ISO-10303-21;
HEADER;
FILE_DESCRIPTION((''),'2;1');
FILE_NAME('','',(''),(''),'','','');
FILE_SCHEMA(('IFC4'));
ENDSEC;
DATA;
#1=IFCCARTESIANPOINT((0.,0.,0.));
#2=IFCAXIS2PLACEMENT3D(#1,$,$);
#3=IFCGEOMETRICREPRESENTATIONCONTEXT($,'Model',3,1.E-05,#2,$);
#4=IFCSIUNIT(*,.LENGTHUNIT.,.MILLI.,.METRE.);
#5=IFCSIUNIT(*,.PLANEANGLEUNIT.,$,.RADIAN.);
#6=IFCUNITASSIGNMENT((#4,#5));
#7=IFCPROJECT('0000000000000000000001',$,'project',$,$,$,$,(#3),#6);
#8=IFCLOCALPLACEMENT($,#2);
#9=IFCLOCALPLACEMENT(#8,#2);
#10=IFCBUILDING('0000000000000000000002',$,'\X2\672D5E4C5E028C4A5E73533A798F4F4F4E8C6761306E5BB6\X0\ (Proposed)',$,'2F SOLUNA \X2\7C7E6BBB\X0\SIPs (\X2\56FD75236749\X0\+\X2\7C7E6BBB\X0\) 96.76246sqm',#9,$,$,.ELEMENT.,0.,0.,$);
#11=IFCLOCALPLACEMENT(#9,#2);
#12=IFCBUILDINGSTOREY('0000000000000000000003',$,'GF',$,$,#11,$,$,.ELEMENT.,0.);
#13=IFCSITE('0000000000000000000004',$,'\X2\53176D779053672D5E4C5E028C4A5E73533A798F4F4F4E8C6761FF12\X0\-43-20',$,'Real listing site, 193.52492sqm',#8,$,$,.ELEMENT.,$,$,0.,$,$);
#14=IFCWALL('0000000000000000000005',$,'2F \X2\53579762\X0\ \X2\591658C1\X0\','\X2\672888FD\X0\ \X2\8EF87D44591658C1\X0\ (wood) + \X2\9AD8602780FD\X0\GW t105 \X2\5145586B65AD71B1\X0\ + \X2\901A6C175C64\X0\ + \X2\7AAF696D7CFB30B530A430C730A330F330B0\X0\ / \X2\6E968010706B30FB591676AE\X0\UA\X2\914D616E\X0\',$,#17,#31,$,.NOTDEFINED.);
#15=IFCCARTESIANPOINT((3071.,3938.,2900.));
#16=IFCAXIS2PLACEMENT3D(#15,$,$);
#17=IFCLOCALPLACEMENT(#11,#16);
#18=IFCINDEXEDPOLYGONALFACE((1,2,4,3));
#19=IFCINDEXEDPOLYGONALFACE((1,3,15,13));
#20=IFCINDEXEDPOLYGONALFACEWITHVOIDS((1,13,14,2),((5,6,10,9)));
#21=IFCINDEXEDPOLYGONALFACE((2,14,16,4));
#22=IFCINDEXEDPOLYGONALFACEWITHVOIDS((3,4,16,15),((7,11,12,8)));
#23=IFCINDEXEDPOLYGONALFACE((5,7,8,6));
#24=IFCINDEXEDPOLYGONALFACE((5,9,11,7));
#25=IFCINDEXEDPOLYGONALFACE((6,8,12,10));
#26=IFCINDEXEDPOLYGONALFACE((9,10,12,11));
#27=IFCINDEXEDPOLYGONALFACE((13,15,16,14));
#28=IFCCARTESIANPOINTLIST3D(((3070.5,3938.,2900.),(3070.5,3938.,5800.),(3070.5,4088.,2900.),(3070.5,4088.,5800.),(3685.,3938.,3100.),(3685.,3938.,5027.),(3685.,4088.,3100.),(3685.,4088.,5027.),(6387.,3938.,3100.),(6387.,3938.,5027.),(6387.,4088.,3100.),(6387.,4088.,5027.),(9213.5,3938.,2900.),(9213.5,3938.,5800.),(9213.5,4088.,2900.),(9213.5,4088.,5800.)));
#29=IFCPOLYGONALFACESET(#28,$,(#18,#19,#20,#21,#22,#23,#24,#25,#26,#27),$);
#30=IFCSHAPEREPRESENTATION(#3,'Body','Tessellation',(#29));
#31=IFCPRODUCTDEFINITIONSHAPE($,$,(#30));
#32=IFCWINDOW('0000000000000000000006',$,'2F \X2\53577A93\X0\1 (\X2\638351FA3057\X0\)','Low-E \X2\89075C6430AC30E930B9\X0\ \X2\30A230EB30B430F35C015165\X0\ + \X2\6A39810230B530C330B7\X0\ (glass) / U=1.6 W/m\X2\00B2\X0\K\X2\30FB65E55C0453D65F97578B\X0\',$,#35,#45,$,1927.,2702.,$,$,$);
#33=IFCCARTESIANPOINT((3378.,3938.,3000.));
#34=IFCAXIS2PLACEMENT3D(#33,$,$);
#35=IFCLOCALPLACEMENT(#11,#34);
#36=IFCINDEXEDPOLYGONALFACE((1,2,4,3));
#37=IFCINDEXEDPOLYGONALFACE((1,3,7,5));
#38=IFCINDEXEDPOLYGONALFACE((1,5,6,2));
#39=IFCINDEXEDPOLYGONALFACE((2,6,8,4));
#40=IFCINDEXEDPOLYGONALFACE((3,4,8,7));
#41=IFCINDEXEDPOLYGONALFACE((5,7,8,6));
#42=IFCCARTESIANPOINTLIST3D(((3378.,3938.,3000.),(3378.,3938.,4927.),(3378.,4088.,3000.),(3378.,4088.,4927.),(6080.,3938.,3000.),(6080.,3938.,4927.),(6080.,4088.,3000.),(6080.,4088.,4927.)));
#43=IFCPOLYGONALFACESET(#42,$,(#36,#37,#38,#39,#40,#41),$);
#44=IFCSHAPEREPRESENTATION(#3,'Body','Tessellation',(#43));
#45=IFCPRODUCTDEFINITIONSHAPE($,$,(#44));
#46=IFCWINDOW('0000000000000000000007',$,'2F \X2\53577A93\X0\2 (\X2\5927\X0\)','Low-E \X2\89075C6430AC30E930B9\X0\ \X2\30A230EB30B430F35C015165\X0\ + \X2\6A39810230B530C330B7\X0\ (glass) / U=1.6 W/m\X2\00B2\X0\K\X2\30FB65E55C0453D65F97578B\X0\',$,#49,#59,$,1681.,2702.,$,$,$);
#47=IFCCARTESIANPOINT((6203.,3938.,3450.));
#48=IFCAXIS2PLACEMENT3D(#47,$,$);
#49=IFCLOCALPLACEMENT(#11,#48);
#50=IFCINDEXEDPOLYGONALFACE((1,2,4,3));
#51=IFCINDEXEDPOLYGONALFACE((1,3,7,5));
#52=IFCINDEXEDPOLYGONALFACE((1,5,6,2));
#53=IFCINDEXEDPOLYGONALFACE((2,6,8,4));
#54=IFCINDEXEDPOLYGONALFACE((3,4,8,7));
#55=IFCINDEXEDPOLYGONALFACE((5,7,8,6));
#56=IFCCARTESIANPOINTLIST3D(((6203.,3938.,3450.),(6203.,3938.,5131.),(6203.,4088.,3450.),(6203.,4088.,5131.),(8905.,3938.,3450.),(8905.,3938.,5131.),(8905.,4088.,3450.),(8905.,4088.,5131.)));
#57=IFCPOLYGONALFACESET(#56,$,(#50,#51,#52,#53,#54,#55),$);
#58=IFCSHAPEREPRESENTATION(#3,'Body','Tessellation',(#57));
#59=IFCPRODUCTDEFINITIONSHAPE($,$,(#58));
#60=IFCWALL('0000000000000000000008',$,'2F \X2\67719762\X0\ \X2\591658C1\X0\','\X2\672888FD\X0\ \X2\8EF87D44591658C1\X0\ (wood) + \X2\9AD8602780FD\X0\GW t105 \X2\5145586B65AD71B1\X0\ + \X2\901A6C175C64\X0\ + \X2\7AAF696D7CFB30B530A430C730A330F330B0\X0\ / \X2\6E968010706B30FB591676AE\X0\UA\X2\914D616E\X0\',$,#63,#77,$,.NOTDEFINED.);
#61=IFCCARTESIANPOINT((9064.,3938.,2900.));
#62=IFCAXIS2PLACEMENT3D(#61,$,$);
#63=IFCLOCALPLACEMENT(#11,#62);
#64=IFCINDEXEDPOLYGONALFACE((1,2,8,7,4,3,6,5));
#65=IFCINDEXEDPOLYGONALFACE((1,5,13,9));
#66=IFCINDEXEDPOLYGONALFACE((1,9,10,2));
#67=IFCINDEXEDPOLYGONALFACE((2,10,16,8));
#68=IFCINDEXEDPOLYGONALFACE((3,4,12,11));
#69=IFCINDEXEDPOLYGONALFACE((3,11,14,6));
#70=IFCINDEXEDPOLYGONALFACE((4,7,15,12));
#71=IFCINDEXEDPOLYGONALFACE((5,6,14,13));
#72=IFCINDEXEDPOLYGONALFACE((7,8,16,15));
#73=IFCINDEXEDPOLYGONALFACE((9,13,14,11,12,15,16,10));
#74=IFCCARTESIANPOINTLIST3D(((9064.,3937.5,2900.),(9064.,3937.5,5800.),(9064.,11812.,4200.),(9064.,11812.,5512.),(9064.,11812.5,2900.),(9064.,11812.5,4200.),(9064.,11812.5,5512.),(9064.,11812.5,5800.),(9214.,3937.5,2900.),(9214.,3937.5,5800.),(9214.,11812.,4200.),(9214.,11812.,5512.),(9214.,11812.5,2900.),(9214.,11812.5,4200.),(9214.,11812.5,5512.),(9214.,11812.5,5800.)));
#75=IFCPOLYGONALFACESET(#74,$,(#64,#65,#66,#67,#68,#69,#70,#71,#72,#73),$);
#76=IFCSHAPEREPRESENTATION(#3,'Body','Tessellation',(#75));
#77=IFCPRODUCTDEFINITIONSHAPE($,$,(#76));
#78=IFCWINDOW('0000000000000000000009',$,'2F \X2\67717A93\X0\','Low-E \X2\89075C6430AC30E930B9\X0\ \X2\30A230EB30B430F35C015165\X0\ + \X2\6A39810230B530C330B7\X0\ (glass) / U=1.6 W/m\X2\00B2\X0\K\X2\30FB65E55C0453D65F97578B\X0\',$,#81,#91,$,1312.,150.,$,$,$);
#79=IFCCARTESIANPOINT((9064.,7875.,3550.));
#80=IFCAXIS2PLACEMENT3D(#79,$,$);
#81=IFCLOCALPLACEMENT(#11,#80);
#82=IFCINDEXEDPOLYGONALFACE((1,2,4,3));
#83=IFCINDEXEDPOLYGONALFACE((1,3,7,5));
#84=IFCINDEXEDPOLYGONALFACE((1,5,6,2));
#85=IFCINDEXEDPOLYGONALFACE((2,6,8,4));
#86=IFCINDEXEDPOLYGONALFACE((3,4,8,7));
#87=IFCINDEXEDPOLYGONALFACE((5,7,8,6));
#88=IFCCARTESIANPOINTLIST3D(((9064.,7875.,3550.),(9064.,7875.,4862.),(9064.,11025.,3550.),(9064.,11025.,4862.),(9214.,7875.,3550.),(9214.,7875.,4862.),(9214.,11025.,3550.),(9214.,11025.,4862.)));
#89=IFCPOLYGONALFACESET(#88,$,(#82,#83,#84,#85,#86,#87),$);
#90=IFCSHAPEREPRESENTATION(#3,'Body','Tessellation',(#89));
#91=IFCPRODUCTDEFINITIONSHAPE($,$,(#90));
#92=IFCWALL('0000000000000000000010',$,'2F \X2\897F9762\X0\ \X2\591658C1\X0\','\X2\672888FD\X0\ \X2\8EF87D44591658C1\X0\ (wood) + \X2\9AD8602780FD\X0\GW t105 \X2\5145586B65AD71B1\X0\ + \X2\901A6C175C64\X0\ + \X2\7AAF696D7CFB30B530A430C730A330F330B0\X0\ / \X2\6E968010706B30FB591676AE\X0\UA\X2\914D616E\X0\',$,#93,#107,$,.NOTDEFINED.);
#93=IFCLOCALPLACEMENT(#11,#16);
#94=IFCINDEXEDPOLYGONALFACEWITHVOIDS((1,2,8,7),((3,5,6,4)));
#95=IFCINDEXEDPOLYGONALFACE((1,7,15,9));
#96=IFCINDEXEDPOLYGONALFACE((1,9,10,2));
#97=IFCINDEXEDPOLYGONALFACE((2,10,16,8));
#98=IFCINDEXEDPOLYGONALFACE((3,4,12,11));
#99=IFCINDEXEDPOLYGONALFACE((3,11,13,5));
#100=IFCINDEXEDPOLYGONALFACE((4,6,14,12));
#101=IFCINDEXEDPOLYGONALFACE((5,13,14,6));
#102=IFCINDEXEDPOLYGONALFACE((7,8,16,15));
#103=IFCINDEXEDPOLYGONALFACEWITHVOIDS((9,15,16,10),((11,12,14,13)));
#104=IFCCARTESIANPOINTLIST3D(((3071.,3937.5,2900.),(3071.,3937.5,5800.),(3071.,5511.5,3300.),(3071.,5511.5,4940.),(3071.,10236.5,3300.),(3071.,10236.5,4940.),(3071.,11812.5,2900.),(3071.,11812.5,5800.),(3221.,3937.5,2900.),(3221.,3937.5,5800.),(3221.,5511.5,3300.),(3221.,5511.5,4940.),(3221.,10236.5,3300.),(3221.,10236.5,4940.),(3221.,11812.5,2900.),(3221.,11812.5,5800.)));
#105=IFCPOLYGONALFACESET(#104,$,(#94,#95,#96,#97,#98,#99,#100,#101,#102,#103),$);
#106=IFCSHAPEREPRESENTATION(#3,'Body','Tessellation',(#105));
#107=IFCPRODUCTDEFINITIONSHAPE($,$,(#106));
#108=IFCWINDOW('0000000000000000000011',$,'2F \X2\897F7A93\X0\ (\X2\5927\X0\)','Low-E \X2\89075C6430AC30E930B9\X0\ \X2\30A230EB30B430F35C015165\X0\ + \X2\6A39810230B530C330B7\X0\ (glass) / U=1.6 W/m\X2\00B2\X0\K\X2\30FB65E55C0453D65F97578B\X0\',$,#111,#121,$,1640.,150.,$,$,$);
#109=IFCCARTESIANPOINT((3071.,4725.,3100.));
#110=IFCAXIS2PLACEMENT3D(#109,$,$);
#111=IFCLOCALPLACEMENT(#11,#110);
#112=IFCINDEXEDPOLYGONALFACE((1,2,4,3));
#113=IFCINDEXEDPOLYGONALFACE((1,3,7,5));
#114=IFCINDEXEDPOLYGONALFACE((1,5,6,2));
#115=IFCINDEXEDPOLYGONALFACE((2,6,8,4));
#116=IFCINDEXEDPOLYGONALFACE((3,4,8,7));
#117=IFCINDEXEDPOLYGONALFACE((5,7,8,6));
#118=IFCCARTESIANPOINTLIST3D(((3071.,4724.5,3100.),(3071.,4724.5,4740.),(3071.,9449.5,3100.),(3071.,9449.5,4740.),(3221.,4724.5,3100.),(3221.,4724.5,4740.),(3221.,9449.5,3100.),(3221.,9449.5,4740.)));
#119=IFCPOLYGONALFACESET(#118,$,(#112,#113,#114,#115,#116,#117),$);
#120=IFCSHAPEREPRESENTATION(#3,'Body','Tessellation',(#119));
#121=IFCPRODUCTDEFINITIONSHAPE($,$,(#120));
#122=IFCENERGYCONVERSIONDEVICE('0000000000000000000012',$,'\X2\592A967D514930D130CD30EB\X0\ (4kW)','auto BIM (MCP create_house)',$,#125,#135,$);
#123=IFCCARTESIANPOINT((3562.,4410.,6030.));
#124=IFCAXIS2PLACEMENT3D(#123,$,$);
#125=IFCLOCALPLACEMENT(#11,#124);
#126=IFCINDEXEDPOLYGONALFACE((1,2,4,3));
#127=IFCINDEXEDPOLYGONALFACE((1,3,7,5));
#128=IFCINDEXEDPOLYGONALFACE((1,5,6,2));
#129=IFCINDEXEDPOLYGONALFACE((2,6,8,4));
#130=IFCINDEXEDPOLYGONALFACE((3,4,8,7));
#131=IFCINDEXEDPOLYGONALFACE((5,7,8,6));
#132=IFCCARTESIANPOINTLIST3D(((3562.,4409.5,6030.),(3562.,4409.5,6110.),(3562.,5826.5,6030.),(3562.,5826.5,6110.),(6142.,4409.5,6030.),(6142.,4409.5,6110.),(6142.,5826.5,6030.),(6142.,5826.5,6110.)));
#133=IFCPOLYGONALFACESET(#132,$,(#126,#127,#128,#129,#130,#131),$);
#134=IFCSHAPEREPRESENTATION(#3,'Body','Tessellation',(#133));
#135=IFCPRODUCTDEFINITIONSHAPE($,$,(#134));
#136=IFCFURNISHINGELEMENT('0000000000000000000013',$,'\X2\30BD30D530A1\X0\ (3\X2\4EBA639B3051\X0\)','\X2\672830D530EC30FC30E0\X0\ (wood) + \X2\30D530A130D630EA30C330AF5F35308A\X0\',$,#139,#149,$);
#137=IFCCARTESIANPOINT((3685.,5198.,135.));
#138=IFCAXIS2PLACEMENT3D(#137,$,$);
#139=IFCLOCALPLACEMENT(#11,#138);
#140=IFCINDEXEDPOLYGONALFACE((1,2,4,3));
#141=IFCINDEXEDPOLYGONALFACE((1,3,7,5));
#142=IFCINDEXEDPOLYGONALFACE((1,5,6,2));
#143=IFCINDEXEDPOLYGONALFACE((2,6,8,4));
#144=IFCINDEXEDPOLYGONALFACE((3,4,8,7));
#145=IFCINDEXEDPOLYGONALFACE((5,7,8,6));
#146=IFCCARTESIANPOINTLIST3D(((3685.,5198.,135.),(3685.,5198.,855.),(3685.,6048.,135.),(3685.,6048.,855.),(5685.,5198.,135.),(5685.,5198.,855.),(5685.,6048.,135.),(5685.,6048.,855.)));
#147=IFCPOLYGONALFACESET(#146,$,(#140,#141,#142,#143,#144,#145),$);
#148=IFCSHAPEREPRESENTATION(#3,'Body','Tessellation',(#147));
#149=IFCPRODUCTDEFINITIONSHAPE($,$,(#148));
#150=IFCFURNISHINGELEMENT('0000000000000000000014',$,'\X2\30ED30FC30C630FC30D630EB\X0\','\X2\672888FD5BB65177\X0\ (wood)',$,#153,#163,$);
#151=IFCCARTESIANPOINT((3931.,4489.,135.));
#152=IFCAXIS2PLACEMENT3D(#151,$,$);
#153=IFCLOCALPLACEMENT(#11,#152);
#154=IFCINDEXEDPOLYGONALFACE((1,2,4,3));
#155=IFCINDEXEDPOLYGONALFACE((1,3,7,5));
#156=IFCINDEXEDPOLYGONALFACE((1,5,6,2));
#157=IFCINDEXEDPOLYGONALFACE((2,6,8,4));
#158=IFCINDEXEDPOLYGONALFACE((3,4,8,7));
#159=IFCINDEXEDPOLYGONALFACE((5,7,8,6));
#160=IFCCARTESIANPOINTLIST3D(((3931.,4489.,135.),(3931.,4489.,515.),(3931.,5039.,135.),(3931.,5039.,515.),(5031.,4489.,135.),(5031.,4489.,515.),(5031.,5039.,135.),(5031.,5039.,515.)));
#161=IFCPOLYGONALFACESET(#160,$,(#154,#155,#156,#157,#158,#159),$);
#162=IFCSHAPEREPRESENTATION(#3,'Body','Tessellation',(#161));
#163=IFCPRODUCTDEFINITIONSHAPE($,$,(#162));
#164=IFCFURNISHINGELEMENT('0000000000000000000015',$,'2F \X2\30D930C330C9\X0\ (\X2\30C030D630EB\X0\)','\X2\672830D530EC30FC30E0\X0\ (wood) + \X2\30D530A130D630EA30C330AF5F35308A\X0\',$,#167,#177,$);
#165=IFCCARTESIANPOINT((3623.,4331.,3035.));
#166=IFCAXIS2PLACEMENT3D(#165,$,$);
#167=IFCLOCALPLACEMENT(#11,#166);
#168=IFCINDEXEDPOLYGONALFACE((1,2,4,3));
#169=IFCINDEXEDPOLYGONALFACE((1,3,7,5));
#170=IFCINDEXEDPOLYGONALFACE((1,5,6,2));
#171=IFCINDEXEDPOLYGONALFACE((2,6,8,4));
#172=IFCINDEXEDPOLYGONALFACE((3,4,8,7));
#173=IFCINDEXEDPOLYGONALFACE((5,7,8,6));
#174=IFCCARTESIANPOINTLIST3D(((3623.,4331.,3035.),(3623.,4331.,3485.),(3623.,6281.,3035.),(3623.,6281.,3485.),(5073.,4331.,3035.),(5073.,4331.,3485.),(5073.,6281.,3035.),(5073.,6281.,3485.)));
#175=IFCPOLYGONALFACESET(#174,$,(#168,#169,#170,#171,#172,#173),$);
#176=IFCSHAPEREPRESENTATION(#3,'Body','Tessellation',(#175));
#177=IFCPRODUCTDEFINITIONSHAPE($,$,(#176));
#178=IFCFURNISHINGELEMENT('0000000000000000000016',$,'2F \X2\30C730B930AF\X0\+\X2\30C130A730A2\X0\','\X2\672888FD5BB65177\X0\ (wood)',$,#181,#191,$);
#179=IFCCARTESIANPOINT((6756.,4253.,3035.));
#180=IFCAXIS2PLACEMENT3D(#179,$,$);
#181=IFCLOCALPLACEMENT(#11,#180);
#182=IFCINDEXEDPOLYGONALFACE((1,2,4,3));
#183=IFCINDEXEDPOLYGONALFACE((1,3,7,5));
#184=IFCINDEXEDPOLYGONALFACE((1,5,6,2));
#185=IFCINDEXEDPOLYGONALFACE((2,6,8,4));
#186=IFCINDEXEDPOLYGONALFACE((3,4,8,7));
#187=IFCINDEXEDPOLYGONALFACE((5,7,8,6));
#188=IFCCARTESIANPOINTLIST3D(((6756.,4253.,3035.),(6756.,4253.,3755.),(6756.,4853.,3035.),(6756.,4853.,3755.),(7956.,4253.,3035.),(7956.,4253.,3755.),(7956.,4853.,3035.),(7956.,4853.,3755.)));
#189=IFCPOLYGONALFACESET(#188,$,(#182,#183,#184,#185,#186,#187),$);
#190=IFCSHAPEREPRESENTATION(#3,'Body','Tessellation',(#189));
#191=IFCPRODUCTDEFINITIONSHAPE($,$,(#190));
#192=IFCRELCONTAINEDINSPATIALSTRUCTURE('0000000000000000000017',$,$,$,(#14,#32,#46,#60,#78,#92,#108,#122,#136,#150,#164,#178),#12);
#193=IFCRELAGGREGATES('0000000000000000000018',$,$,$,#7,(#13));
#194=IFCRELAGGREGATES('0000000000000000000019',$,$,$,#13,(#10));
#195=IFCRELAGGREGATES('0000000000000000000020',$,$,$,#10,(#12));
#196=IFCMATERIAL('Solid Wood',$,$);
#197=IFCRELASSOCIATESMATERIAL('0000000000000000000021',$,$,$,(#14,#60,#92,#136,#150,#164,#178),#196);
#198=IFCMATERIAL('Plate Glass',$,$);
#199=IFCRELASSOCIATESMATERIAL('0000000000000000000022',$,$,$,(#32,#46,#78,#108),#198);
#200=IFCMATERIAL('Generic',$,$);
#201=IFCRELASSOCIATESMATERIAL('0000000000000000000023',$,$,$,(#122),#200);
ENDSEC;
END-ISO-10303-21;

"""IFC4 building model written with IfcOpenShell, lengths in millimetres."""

from ifc_helpers import new_model, si_unit, frame, frame_2d, origin, place, context, project, spatial, rectangle, extrude, material, element, fill, save


model = new_model("IFC4")

# Units and contexts
model_context = context("Model", 3, precision=1e-05, world=origin())
ifc_project = project(units=[si_unit("LENGTHUNIT", "METRE", prefix="MILLI"), si_unit("PLANEANGLEUNIT", "RADIAN")], contexts=[model_context])

# Site, building, storey
site_placement = place(None, origin())
site = spatial("IfcSite", under=ifc_project, at=site_placement, Name="北海道札幌市豊平区福住二条２-43-20", ObjectType="Real listing site, 193.52492sqm", CompositionType="ELEMENT", RefElevation=0.0)
building_placement = place(site_placement, origin())
building = spatial("IfcBuilding", under=site, at=building_placement, Name="札幌市豊平区福住二条の家 (Proposed)", ObjectType="2F SOLUNA 籾殻SIPs (国産杉+籾殻) 96.76246sqm", CompositionType="ELEMENT", ElevationOfRefHeight=0.0, ElevationOfTerrain=0.0)
storey_placement = place(building_placement, origin())
storey = spatial("IfcBuildingStorey", under=building, at=storey_placement, Name="GF", CompositionType="ELEMENT", Elevation=0.0)

# Shared definitions
ifc_material_1 = material(Name="Solid Wood")

# Wall, openings, windows
wall_1_placement = place(storey_placement, frame((3071.0, 3938.0, 2900.0)))
wall_1 = element("IfcWall", 1, at=wall_1_placement, inside=storey, material=ifc_material_1, Name="2F 南面 外壁", Description="木製 軸組外壁 (wood) + 高性能GW t105 充填断熱 + 通気層 + 窯業系サイディング / 準耐火・外皮UA配慮", PredefinedType="NOTDEFINED", context=model_context, shape_type="SweptSolid", body=[
    extrude(rectangle(XDim=6143.0, YDim=150.0, at=frame_2d((3071.0, 75.0))), frame((3071.0, 3938.0, 2900.0)), (0.0, 0.0, 1.0), 2900.0),
])
opening_1_placement = place(storey_placement, frame((3378.0, 3938.0, 3000.0)))
opening_1 = element("IfcOpeningElement", 2, at=opening_1_placement, cuts=wall_1, PredefinedType="NOTDEFINED", context=model_context, shape_type="SweptSolid", body=[
    extrude(rectangle(XDim=2702.0, YDim=150.0, at=frame_2d((1351.0, 75.0))), frame((3378.0, 3938.0, 3000.0)), (0.0, 0.0, 1.0), 1927.0),
])
opening_2_placement = place(storey_placement, frame((6203.0, 3938.0, 3450.0)))
opening_2 = element("IfcOpeningElement", 3, at=opening_2_placement, cuts=wall_1, PredefinedType="NOTDEFINED", context=model_context, shape_type="SweptSolid", body=[
    extrude(rectangle(XDim=2702.0, YDim=150.0, at=frame_2d((1351.0, 75.0))), frame((6203.0, 3938.0, 3450.0)), (0.0, 0.0, 1.0), 1681.0),
])
ifc_material_2 = material(Name="Plate Glass")
window_1_placement = place(storey_placement, frame((3378.0, 3938.0, 3000.0)))
window_1 = element("IfcWindow", 4, at=window_1_placement, inside=storey, material=ifc_material_2, Name="2F 南窓1 (掃出し)", Description="Low-E 複層ガラス アルゴン封入 + 樹脂サッシ (glass) / U=1.6 W/m²K・日射取得型", OverallHeight=1927.0, OverallWidth=2702.0, context=model_context, shape_type="SweptSolid", body=[
    extrude(rectangle(XDim=2702.0, YDim=150.0, at=frame_2d((1351.0, 75.0))), frame((3378.0, 3938.0, 3000.0)), (0.0, 0.0, 1.0), 1927.0),
])
fill(opening_1, window_1)
window_2_placement = place(storey_placement, frame((6203.0, 3938.0, 3450.0)))
window_2 = element("IfcWindow", 5, at=window_2_placement, inside=storey, material=ifc_material_2, Name="2F 南窓2 (大)", Description="Low-E 複層ガラス アルゴン封入 + 樹脂サッシ (glass) / U=1.6 W/m²K・日射取得型", OverallHeight=1681.0, OverallWidth=2702.0, context=model_context, shape_type="SweptSolid", body=[
    extrude(rectangle(XDim=2702.0, YDim=150.0, at=frame_2d((1351.0, 75.0))), frame((6203.0, 3938.0, 3450.0)), (0.0, 0.0, 1.0), 1681.0),
])
fill(opening_2, window_2)

# Walls, openings, windows
wall_2_placement = place(storey_placement, frame((9064.0, 3938.0, 2900.0)))
wall_2 = element("IfcWall", 6, at=wall_2_placement, inside=storey, material=ifc_material_1, Name="2F 東面 外壁", Description="木製 軸組外壁 (wood) + 高性能GW t105 充填断熱 + 通気層 + 窯業系サイディング / 準耐火・外皮UA配慮", PredefinedType="NOTDEFINED", context=model_context, shape_type="SweptSolid", body=[
    extrude(rectangle(XDim=150.0, YDim=7875.0, at=frame_2d((75.0, 3937.0))), frame((9064.0, 3938.0, 2900.0)), (0.0, 0.0, 1.0), 2900.0),
])
opening_3_placement = place(storey_placement, frame((9064.0, 7875.0, 3550.0)))
opening_3 = element("IfcOpeningElement", 7, at=opening_3_placement, cuts=wall_2, PredefinedType="NOTDEFINED", context=model_context, shape_type="SweptSolid", body=[
    extrude(rectangle(XDim=150.0, YDim=3150.0, at=frame_2d((75.0, 1575.0))), frame((9064.0, 7875.0, 3550.0)), (0.0, 0.0, 1.0), 1312.0),
])
window_3_placement = place(storey_placement, frame((9064.0, 7875.0, 3550.0)))
window_3 = element("IfcWindow", 8, at=window_3_placement, inside=storey, material=ifc_material_2, Name="2F 東窓", Description="Low-E 複層ガラス アルゴン封入 + 樹脂サッシ (glass) / U=1.6 W/m²K・日射取得型", OverallHeight=1312.0, OverallWidth=150.0, context=model_context, shape_type="SweptSolid", body=[
    extrude(rectangle(XDim=150.0, YDim=3150.0, at=frame_2d((75.0, 1575.0))), frame((9064.0, 7875.0, 3550.0)), (0.0, 0.0, 1.0), 1312.0),
])
fill(opening_3, window_3)
wall_3_placement = place(storey_placement, frame((3071.0, 3938.0, 2900.0)))
wall_3 = element("IfcWall", 9, at=wall_3_placement, inside=storey, material=ifc_material_1, Name="2F 西面 外壁", Description="木製 軸組外壁 (wood) + 高性能GW t105 充填断熱 + 通気層 + 窯業系サイディング / 準耐火・外皮UA配慮", PredefinedType="NOTDEFINED", context=model_context, shape_type="SweptSolid", body=[
    extrude(rectangle(XDim=150.0, YDim=7875.0, at=frame_2d((75.0, 3937.0))), frame((3071.0, 3938.0, 2900.0)), (0.0, 0.0, 1.0), 2900.0),
])
opening_4_placement = place(storey_placement, frame((3071.0, 4725.0, 3100.0)))
opening_4 = element("IfcOpeningElement", 10, at=opening_4_placement, cuts=wall_3, PredefinedType="NOTDEFINED", context=model_context, shape_type="SweptSolid", body=[
    extrude(rectangle(XDim=150.0, YDim=4725.0, at=frame_2d((75.0, 2362.0))), frame((3071.0, 4725.0, 3100.0)), (0.0, 0.0, 1.0), 1640.0),
])
window_4_placement = place(storey_placement, frame((3071.0, 4725.0, 3100.0)))
window_4 = element("IfcWindow", 11, at=window_4_placement, inside=storey, material=ifc_material_2, Name="2F 西窓 (大)", Description="Low-E 複層ガラス アルゴン封入 + 樹脂サッシ (glass) / U=1.6 W/m²K・日射取得型", OverallHeight=1640.0, OverallWidth=150.0, context=model_context, shape_type="SweptSolid", body=[
    extrude(rectangle(XDim=150.0, YDim=4725.0, at=frame_2d((75.0, 2362.0))), frame((3071.0, 4725.0, 3100.0)), (0.0, 0.0, 1.0), 1640.0),
])
fill(opening_4, window_4)

# Shared definitions
ifc_material_3 = material(Name="Generic")

# Energy conversion device
energy_conversion_device_placement = place(storey_placement, frame((3562.0, 4410.0, 6030.0)))
element("IfcEnergyConversionDevice", 12, at=energy_conversion_device_placement, inside=storey, material=ifc_material_3, Name="太陽光パネル (4kW)", Description="auto BIM (MCP create_house)", context=model_context, shape_type="SweptSolid", body=[
    extrude(rectangle(XDim=2580.0, YDim=1417.0, at=frame_2d((1290.0, 708.0))), frame((3562.0, 4410.0, 6030.0)), (0.0, 0.0, 1.0), 80.0),
])

# Furnishing elements
furnishing_1_placement = place(storey_placement, frame((3685.0, 5198.0, 135.0)))
element("IfcFurnishingElement", 13, at=furnishing_1_placement, inside=storey, material=ifc_material_1, Name="ソファ (3人掛け)", Description="木フレーム (wood) + ファブリック張り", context=model_context, shape_type="SweptSolid", body=[
    extrude(rectangle(XDim=2000.0, YDim=850.0, at=frame_2d((1000.0, 425.0))), frame((3685.0, 5198.0, 135.0)), (0.0, 0.0, 1.0), 720.0),
])
furnishing_2_placement = place(storey_placement, frame((3931.0, 4489.0, 135.0)))
element("IfcFurnishingElement", 14, at=furnishing_2_placement, inside=storey, material=ifc_material_1, Name="ローテーブル", Description="木製家具 (wood)", context=model_context, shape_type="SweptSolid", body=[
    extrude(rectangle(XDim=1100.0, YDim=550.0, at=frame_2d((550.0, 275.0))), frame((3931.0, 4489.0, 135.0)), (0.0, 0.0, 1.0), 380.0),
])
furnishing_3_placement = place(storey_placement, frame((3623.0, 4331.0, 3035.0)))
element("IfcFurnishingElement", 15, at=furnishing_3_placement, inside=storey, material=ifc_material_1, Name="2F ベッド (ダブル)", Description="木フレーム (wood) + ファブリック張り", context=model_context, shape_type="SweptSolid", body=[
    extrude(rectangle(XDim=1450.0, YDim=1950.0, at=frame_2d((725.0, 975.0))), frame((3623.0, 4331.0, 3035.0)), (0.0, 0.0, 1.0), 450.0),
])
furnishing_4_placement = place(storey_placement, frame((6756.0, 4253.0, 3035.0)))
element("IfcFurnishingElement", 16, at=furnishing_4_placement, inside=storey, material=ifc_material_1, Name="2F デスク+チェア", Description="木製家具 (wood)", context=model_context, shape_type="SweptSolid", body=[
    extrude(rectangle(XDim=1200.0, YDim=600.0, at=frame_2d((600.0, 300.0))), frame((6756.0, 4253.0, 3035.0)), (0.0, 0.0, 1.0), 720.0),
])

save(model, "model.ifc")
